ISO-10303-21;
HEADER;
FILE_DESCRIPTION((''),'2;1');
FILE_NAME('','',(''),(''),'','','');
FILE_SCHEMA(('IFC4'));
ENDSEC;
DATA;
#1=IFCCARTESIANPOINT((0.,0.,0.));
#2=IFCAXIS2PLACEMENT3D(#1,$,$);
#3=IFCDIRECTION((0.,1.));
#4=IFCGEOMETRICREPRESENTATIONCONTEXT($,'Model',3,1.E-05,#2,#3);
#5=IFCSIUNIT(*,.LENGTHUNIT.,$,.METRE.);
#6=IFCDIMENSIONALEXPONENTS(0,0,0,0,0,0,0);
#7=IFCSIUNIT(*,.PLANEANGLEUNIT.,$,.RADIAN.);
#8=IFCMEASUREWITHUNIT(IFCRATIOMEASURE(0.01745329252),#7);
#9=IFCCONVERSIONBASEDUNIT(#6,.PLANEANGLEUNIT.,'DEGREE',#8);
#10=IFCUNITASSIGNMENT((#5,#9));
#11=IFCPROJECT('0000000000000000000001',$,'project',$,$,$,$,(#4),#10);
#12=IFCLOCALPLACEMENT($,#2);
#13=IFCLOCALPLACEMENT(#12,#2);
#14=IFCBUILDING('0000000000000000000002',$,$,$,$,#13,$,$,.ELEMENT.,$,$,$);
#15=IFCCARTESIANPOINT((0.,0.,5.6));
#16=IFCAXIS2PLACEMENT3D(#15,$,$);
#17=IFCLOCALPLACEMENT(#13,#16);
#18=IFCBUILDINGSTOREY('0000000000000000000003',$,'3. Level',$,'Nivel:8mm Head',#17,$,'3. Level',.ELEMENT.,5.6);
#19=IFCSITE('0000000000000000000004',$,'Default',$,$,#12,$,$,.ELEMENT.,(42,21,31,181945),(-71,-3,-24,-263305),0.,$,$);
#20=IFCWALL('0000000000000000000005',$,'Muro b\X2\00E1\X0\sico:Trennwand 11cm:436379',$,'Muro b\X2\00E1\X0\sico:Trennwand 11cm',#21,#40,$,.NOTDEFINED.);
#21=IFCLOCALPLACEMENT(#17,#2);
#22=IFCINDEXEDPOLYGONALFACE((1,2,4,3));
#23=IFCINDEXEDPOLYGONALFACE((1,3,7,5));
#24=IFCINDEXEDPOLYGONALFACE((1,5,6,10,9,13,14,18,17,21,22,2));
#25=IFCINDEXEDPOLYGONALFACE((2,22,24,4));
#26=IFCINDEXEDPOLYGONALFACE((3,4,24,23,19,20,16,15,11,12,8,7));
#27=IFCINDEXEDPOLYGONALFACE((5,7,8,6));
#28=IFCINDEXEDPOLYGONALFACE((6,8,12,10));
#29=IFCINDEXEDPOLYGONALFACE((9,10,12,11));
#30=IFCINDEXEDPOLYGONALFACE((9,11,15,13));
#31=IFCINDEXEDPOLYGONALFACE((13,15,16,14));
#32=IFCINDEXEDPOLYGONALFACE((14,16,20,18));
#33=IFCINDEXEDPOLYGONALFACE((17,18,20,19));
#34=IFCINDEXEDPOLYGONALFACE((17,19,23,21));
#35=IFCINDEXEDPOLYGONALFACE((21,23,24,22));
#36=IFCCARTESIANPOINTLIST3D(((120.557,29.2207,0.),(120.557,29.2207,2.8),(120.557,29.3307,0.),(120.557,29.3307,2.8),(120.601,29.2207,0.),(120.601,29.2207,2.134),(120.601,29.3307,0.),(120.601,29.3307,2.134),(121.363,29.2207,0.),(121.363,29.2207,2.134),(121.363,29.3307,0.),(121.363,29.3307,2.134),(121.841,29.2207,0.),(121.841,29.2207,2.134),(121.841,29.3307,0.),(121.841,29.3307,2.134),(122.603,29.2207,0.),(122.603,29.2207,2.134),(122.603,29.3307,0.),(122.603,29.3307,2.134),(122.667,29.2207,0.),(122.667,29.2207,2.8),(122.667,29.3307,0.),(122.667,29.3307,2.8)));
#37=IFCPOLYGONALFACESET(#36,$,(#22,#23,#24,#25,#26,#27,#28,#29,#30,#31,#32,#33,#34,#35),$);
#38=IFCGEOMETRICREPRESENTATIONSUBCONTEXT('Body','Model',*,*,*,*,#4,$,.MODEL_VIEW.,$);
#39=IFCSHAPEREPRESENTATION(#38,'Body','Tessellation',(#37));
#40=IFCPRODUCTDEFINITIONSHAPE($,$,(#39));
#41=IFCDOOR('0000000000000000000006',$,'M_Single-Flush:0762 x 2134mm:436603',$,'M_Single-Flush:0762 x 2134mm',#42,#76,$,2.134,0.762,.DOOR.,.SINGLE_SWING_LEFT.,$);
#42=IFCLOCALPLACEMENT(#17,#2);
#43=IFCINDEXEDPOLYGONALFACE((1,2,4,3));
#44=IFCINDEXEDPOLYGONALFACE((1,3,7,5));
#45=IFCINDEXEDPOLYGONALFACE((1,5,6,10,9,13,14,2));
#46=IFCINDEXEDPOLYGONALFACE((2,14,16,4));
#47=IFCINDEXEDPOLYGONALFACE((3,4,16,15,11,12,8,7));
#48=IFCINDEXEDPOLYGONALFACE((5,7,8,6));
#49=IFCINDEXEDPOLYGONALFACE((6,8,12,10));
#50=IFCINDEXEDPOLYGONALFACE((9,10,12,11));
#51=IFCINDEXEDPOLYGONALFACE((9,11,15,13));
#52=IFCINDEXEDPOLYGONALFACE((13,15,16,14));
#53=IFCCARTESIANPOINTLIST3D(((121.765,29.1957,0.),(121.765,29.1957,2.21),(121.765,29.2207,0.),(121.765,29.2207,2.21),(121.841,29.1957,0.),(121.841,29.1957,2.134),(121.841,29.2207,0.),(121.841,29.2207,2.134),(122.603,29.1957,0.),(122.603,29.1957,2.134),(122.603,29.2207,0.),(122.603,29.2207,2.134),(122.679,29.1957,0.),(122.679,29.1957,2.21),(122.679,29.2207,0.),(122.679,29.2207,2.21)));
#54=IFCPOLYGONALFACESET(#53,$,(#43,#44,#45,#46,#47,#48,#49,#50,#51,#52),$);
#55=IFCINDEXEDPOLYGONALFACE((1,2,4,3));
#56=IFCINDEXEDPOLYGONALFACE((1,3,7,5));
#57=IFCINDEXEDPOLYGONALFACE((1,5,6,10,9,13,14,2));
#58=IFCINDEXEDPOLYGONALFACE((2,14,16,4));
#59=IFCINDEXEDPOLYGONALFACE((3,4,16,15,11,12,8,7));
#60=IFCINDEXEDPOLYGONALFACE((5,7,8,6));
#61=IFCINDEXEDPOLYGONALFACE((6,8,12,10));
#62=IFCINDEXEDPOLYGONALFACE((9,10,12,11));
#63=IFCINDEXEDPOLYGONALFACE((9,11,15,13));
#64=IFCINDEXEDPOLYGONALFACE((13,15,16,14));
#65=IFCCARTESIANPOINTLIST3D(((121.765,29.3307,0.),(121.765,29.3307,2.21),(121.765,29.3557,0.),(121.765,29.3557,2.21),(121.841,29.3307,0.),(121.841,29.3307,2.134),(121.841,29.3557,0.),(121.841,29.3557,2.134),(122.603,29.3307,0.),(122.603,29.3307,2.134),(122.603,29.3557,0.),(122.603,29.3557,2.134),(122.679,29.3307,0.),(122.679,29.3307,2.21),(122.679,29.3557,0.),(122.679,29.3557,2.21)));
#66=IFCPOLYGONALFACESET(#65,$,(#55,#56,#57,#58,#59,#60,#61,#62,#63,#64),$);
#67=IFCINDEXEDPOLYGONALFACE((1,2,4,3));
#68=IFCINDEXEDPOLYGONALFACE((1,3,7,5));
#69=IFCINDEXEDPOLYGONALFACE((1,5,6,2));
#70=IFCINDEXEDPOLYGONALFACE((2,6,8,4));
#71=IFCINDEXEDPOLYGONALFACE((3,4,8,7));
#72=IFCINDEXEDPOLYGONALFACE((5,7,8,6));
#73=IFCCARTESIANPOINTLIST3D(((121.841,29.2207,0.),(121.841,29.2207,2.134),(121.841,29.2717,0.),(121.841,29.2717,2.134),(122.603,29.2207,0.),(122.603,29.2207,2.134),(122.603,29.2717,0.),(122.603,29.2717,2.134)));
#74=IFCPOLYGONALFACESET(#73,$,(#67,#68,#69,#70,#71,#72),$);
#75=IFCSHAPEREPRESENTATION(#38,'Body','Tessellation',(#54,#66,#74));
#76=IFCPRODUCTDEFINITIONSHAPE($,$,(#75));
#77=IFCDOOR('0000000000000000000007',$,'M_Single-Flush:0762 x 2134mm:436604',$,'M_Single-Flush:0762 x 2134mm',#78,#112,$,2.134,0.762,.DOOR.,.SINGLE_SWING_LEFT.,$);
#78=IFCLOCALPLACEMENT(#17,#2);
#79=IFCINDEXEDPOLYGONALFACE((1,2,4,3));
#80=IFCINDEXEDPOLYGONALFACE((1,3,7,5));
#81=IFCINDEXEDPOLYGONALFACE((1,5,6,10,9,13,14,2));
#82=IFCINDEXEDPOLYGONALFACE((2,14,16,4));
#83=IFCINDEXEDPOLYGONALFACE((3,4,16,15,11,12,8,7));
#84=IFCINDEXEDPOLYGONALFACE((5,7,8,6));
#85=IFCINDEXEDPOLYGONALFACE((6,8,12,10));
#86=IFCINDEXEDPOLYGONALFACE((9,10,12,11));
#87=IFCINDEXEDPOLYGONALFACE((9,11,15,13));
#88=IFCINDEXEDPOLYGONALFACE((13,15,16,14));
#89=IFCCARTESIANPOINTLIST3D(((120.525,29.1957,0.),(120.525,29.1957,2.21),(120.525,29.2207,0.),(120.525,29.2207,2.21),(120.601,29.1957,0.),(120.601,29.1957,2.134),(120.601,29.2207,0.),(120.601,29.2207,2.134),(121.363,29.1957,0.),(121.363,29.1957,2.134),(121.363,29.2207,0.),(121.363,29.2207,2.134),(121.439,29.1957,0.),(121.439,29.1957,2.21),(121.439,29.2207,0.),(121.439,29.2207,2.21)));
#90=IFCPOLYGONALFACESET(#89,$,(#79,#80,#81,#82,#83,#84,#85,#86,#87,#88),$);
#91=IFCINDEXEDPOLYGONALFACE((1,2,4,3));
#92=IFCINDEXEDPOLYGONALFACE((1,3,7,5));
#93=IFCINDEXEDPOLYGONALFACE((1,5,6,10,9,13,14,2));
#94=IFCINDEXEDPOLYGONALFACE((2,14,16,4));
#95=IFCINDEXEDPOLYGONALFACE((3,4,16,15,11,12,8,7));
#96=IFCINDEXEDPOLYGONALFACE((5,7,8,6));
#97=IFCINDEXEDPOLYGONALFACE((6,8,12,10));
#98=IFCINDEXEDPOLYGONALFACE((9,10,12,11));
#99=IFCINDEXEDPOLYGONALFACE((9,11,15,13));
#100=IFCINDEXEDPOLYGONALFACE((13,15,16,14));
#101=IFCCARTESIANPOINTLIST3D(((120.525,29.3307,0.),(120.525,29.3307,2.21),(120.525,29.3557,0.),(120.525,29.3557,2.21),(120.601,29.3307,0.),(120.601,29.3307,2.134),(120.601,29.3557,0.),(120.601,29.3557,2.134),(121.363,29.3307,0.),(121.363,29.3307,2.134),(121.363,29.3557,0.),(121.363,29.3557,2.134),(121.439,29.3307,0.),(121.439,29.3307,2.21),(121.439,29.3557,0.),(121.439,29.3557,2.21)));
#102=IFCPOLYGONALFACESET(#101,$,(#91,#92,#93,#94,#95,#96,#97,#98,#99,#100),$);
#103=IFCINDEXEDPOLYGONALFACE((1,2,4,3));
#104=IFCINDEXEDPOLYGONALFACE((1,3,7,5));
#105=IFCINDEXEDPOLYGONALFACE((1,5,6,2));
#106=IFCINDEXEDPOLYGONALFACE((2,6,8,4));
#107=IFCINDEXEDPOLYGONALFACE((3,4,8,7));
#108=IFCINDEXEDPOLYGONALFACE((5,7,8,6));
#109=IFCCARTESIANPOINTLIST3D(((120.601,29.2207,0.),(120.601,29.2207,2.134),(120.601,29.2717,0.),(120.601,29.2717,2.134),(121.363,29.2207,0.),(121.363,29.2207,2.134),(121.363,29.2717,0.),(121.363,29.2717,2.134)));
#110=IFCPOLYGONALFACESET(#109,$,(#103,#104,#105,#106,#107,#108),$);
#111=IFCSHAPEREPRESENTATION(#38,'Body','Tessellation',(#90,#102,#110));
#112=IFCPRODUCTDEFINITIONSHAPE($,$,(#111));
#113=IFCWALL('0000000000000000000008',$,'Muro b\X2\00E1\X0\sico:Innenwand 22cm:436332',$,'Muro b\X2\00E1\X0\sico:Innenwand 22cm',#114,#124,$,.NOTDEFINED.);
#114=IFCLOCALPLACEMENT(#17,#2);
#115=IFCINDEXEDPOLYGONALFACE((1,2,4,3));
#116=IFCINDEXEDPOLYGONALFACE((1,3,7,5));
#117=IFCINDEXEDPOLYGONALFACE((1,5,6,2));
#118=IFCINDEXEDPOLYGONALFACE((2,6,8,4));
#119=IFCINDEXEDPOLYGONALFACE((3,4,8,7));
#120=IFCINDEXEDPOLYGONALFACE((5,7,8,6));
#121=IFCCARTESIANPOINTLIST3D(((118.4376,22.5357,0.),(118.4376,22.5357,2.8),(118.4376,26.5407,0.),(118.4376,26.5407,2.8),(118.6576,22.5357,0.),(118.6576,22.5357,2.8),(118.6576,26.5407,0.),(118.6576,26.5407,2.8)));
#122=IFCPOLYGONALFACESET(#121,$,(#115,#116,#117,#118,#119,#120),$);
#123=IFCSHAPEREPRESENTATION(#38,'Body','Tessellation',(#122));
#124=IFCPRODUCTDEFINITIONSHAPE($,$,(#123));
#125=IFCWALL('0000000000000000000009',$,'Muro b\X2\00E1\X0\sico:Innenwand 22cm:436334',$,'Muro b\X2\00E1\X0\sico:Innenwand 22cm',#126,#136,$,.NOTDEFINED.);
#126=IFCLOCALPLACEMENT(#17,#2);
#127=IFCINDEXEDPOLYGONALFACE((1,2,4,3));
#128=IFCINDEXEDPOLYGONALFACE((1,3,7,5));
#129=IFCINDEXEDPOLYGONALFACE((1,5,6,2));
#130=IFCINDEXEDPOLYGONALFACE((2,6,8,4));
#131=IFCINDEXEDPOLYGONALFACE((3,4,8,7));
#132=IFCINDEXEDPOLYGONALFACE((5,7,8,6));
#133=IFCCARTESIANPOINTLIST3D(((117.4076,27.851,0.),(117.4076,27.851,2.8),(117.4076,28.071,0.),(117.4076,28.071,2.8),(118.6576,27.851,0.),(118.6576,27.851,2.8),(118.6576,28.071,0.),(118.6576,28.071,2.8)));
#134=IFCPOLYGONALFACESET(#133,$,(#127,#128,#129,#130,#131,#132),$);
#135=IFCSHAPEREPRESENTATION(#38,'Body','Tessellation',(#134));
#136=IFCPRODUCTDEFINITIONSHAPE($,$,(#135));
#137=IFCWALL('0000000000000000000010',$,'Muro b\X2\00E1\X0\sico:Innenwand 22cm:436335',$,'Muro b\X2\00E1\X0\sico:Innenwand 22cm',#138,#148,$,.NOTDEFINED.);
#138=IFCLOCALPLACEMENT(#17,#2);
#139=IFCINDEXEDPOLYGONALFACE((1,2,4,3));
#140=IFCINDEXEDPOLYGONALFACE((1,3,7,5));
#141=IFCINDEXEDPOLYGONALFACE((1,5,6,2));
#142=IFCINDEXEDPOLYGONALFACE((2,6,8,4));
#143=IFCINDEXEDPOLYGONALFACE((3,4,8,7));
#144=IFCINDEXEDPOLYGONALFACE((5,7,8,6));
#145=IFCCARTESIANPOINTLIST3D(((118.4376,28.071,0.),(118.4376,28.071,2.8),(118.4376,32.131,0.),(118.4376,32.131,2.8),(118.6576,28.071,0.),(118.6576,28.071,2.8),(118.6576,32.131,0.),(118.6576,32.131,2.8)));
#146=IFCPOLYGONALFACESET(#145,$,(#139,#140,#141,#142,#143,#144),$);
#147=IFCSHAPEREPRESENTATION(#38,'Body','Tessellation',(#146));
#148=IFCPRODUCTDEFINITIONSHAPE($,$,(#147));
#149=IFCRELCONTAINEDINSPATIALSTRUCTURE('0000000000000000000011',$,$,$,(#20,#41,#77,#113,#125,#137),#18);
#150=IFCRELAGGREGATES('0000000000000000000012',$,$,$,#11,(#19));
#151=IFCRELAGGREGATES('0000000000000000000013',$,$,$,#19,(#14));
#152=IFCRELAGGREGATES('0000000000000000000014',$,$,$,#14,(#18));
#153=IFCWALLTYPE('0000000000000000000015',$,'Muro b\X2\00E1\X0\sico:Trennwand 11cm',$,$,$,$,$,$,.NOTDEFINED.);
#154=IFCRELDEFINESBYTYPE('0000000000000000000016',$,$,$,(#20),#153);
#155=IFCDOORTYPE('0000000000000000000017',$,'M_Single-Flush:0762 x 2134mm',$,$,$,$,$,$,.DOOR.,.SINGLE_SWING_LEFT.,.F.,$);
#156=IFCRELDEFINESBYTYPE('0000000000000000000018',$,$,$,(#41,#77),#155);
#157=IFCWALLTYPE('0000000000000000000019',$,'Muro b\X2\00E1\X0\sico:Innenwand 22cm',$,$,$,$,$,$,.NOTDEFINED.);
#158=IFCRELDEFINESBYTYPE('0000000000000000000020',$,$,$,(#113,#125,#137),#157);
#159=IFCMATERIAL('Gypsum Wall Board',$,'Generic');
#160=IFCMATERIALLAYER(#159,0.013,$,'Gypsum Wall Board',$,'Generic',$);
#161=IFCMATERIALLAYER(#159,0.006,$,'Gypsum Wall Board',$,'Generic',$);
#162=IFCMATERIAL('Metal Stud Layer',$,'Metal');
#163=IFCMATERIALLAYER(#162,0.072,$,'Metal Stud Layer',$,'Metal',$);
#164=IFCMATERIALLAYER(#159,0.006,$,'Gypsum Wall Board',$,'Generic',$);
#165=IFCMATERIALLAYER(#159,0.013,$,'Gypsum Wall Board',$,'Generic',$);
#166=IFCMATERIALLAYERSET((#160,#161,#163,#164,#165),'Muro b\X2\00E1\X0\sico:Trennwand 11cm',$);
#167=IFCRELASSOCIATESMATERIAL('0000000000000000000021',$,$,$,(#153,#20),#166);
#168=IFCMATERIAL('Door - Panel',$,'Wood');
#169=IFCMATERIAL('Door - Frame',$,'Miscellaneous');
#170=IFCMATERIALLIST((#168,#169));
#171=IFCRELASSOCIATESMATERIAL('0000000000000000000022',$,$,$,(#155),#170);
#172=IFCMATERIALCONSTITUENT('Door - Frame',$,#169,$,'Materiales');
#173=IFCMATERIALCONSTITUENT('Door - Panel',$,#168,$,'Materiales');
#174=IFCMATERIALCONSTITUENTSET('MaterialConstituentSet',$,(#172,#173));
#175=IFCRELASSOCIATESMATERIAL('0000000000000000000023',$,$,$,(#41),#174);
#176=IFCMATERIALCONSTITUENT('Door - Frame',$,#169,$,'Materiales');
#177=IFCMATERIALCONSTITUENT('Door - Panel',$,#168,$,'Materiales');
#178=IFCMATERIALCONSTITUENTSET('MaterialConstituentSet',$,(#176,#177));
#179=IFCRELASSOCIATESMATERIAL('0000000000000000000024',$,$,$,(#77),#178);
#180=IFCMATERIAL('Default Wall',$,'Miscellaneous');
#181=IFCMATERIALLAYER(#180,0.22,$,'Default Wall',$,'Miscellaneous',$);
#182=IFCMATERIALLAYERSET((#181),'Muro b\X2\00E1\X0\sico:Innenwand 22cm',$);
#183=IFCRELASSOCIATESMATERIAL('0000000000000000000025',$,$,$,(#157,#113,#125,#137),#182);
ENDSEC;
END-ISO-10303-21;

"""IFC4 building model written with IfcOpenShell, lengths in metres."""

from ifc_helpers import new_model, entity, si_unit, converted_unit, direction, frame, frame_2d, origin, origin_2d_with_axis, place, context, subcontext, project, spatial, polyline, rectangle, outline, extrude, source, transform, mapped, material, material_list, layer, layer_set, layer_usage, constituent, constituent_set, type_object, type_shapes, element, fill, save


model = new_model("IFC4")

# Units and contexts
model_context = context("Model", 3, precision=1e-05, world=origin(), true_north=direction((0.0, 1.0)))
body_context = subcontext(model_context, "Body", "Model", "MODEL_VIEW")
ifc_project = project(units=[si_unit("LENGTHUNIT", "METRE"), converted_unit("PLANEANGLEUNIT", "DEGREE", entity("IfcRatioMeasure", 0.01745329252), si_unit("PLANEANGLEUNIT", "RADIAN"), dimensions=[0, 0, 0, 0, 0, 0, 0])], contexts=[model_context])

# Site, building, storey
site_placement = place(None, origin())
site = spatial("IfcSite", under=ifc_project, at=site_placement, Name="Default", CompositionType="ELEMENT", RefLatitude=(42, 21, 31, 181945), RefLongitude=(-71, -3, -24, -263305), RefElevation=0.0)
building_placement = place(site_placement, origin())
building = spatial("IfcBuilding", under=site, at=building_placement, CompositionType="ELEMENT")
storey_placement = place(building_placement, frame((0.0, 0.0, 5.6)))
storey = spatial("IfcBuildingStorey", under=building, at=storey_placement, Name="3. Level", ObjectType="Nivel:8mm Head", LongName="3. Level", CompositionType="ELEMENT", Elevation=5.6)

# Shared definitions
ifc_material_1 = material(Name="Gypsum Wall Board", Category="Generic")
ifc_layer_1 = layer(ifc_material_1, 0.013, Name="Gypsum Wall Board", Category="Generic")
ifc_layer_2 = layer(ifc_material_1, 0.006, Name="Gypsum Wall Board", Category="Generic")
ifc_material_2 = material(Name="Metal Stud Layer", Category="Metal")
ifc_layer_3 = layer(ifc_material_2, 0.072, Name="Metal Stud Layer", Category="Metal")
ifc_layer_4 = layer(ifc_material_1, 0.006, Name="Gypsum Wall Board", Category="Generic")
ifc_layer_5 = layer(ifc_material_1, 0.013, Name="Gypsum Wall Board", Category="Generic")
ifc_layer_set_1 = layer_set([ifc_layer_1, ifc_layer_2, ifc_layer_3, ifc_layer_4, ifc_layer_5], Name="Muro básico:Trennwand 11cm")
wall_type_1 = type_object("IfcWallType", Name="Muro básico:Trennwand 11cm", PredefinedType="NOTDEFINED", material=ifc_layer_set_1)
ifc_material_3 = material(Name="Door - Frame", Category="Miscellaneous")

# Shared definitions
ifc_material_4 = material(Name="Door - Panel", Category="Wood")
ifc_material_list_1 = material_list([ifc_material_4, ifc_material_3])
door_type_1 = type_object("IfcDoorType", Name="M_Single-Flush:0762 x 2134mm", OperationType="SINGLE_SWING_LEFT", ParameterTakesPrecedence=False, PredefinedType="DOOR", material=ifc_material_list_1)
shared_shape_1 = source(origin(), body_context, "Body", "SweptSolid", [
    extrude(outline(polyline([(-0.457, -1.124), (0.457, -1.124), (0.457, 1.086), (0.381, 1.086), (0.381, -1.048), (-0.381, -1.048), (-0.381, 1.086), (-0.457, 1.086), (-0.457, -1.124)])), frame((0.381, 0.135, 1.086), z_axis=(0.0, -1.0, 0.0), x_axis=(-1.0, 0.0, 0.0)), (0.0, 0.0, 1.0), 0.025),
    extrude(outline(polyline([(-1.124, -0.457), (1.086, -0.457), (1.086, -0.381), (-1.048, -0.381), (-1.048, 0.381), (1.086, 0.381), (1.086, 0.457), (-1.124, 0.457), (-1.124, -0.457)])), frame((0.381, 0.0, 1.086), z_axis=(0.0, -1.0, 0.0), x_axis=(0.0, 0.0, -1.0)), (0.0, 0.0, 1.0), 0.025),
    extrude(rectangle(XDim=0.762, YDim=0.051, at=origin_2d_with_axis()), frame((0.381, 0.0845, 0.0)), (0.0, 0.0, 1.0), 2.134),
])
type_shapes(door_type_1, [shared_shape_1])

# Wall, openings, doors
ifc_layer_usage_1 = layer_usage(ifc_layer_set_1, "AXIS2", "NEGATIVE", 0.055)
wall_1_placement = place(storey_placement, frame((122.667, 29.2757, 0.0), z_axis=(0.0, 0.0, 1.0), x_axis=(-1.0, 0.0, 0.0)))
wall_1 = element("IfcWall", 1, at=wall_1_placement, inside=storey, type_object=wall_type_1, material=ifc_layer_usage_1, Name="Muro básico:Trennwand 11cm:436379", ObjectType="Muro básico:Trennwand 11cm", PredefinedType="NOTDEFINED", context=body_context, shape_type="SweptSolid", body=[
    extrude(rectangle(XDim=2.11, YDim=0.11, at=frame_2d((1.055, 0.0), x_axis=(-1.0, 0.0))), origin(), (0.0, 0.0, 1.0), 2.8),
])
opening_1_placement = place(wall_1_placement, frame((0.064, -0.055, 0.0)))
opening_1 = element("IfcOpeningElement", 2, at=opening_1_placement, cuts=wall_1, ObjectType="Opening", PredefinedType="OPENING", context=body_context, shape_type="SweptSolid", body=[
    extrude(rectangle(XDim=0.762, YDim=2.134, at=frame_2d((1.067, 0.381), x_axis=(0.0, -1.0))), frame((0.0, 0.0, 0.0), z_axis=(0.0, 1.0, 0.0), x_axis=(0.0, 0.0, 1.0)), (0.0, 0.0, 1.0), 0.11),
])
opening_2_placement = place(wall_1_placement, frame((1.304, -0.055, 0.0)))
opening_2 = element("IfcOpeningElement", 3, at=opening_2_placement, cuts=wall_1, ObjectType="Opening", PredefinedType="OPENING", context=body_context, shape_type="SweptSolid", body=[
    extrude(rectangle(XDim=0.762, YDim=2.134, at=frame_2d((1.067, 0.381), x_axis=(0.0, -1.0))), frame((0.0, 0.0, 0.0), z_axis=(0.0, 1.0, 0.0), x_axis=(0.0, 0.0, 1.0)), (0.0, 0.0, 1.0), 0.11),
])
ifc_constituent_1 = constituent(ifc_material_3, Name="Door - Frame", Category="Materiales")
ifc_constituent_2 = constituent(ifc_material_4, Name="Door - Panel", Category="Materiales")
ifc_constituent_set_1 = constituent_set(constituents=[ifc_constituent_1, ifc_constituent_2], Name="MaterialConstituentSet")
door_1_placement = place(opening_1_placement, origin())
door_1 = element("IfcDoor", 4, at=door_1_placement, inside=storey, type_object=door_type_1, material=ifc_constituent_set_1, Name="M_Single-Flush:0762 x 2134mm:436603", ObjectType="M_Single-Flush:0762 x 2134mm", OperationType="SINGLE_SWING_LEFT", OverallHeight=2.134, OverallWidth=0.762, PredefinedType="DOOR", context=body_context, shape_type="MappedRepresentation", body=[
    mapped(shared_shape_1, transform((0.0, 0.0, 0.0), scale=1.0)),
])
fill(opening_1, door_1)
ifc_constituent_3 = constituent(ifc_material_3, Name="Door - Frame", Category="Materiales")
ifc_constituent_4 = constituent(ifc_material_4, Name="Door - Panel", Category="Materiales")
ifc_constituent_set_2 = constituent_set(constituents=[ifc_constituent_3, ifc_constituent_4], Name="MaterialConstituentSet")
door_2_placement = place(opening_2_placement, origin())
door_2 = element("IfcDoor", 5, at=door_2_placement, inside=storey, type_object=door_type_1, material=ifc_constituent_set_2, Name="M_Single-Flush:0762 x 2134mm:436604", ObjectType="M_Single-Flush:0762 x 2134mm", OperationType="SINGLE_SWING_LEFT", OverallHeight=2.134, OverallWidth=0.762, PredefinedType="DOOR", context=body_context, shape_type="MappedRepresentation", body=[
    mapped(shared_shape_1, transform((0.0, 0.0, 0.0), scale=1.0)),
])
fill(opening_2, door_2)

# Walls
ifc_material_5 = material(Name="Default Wall", Category="Miscellaneous")
ifc_layer_6 = layer(ifc_material_5, 0.22, Name="Default Wall", Category="Miscellaneous")
ifc_layer_set_2 = layer_set([ifc_layer_6], Name="Muro básico:Innenwand 22cm")
ifc_layer_usage_2 = layer_usage(ifc_layer_set_2, "AXIS2", "NEGATIVE", 0.11)
wall_type_2 = type_object("IfcWallType", Name="Muro básico:Innenwand 22cm", PredefinedType="NOTDEFINED", material=ifc_layer_set_2)
wall_2_placement = place(storey_placement, frame((118.5476, 22.5357, 0.0), z_axis=(0.0, 0.0, 1.0), x_axis=(0.0, 1.0, 0.0)))
element("IfcWall", 6, at=wall_2_placement, inside=storey, type_object=wall_type_2, material=ifc_layer_usage_2, Name="Muro básico:Innenwand 22cm:436332", ObjectType="Muro básico:Innenwand 22cm", PredefinedType="NOTDEFINED", context=body_context, shape_type="SweptSolid", body=[
    extrude(rectangle(XDim=4.005, YDim=0.22, at=frame_2d((2.0025, 0.0), x_axis=(-1.0, 0.0))), origin(), (0.0, 0.0, 1.0), 2.8),
])
ifc_layer_usage_3 = layer_usage(ifc_layer_set_2, "AXIS2", "NEGATIVE", 0.11)
wall_3_placement = place(storey_placement, frame((117.4076, 27.961, 0.0)))
element("IfcWall", 7, at=wall_3_placement, inside=storey, type_object=wall_type_2, material=ifc_layer_usage_3, Name="Muro básico:Innenwand 22cm:436334", ObjectType="Muro básico:Innenwand 22cm", PredefinedType="NOTDEFINED", context=body_context, shape_type="SweptSolid", body=[
    extrude(rectangle(XDim=1.25, YDim=0.22, at=frame_2d((0.625, 0.0), x_axis=(-1.0, 0.0))), origin(), (0.0, 0.0, 1.0), 2.8),
])
ifc_layer_usage_4 = layer_usage(ifc_layer_set_2, "AXIS2", "NEGATIVE", 0.11)
wall_4_placement = place(storey_placement, frame((118.5476, 28.071, 0.0), z_axis=(0.0, 0.0, 1.0), x_axis=(0.0, 1.0, 0.0)))
element("IfcWall", 8, at=wall_4_placement, inside=storey, type_object=wall_type_2, material=ifc_layer_usage_4, Name="Muro básico:Innenwand 22cm:436335", ObjectType="Muro básico:Innenwand 22cm", PredefinedType="NOTDEFINED", context=body_context, shape_type="SweptSolid", body=[
    extrude(rectangle(XDim=4.06, YDim=0.22, at=frame_2d((2.03, 0.0), x_axis=(-1.0, 0.0))), origin(), (0.0, 0.0, 1.0), 2.8),
])

save(model, "model.ifc")
